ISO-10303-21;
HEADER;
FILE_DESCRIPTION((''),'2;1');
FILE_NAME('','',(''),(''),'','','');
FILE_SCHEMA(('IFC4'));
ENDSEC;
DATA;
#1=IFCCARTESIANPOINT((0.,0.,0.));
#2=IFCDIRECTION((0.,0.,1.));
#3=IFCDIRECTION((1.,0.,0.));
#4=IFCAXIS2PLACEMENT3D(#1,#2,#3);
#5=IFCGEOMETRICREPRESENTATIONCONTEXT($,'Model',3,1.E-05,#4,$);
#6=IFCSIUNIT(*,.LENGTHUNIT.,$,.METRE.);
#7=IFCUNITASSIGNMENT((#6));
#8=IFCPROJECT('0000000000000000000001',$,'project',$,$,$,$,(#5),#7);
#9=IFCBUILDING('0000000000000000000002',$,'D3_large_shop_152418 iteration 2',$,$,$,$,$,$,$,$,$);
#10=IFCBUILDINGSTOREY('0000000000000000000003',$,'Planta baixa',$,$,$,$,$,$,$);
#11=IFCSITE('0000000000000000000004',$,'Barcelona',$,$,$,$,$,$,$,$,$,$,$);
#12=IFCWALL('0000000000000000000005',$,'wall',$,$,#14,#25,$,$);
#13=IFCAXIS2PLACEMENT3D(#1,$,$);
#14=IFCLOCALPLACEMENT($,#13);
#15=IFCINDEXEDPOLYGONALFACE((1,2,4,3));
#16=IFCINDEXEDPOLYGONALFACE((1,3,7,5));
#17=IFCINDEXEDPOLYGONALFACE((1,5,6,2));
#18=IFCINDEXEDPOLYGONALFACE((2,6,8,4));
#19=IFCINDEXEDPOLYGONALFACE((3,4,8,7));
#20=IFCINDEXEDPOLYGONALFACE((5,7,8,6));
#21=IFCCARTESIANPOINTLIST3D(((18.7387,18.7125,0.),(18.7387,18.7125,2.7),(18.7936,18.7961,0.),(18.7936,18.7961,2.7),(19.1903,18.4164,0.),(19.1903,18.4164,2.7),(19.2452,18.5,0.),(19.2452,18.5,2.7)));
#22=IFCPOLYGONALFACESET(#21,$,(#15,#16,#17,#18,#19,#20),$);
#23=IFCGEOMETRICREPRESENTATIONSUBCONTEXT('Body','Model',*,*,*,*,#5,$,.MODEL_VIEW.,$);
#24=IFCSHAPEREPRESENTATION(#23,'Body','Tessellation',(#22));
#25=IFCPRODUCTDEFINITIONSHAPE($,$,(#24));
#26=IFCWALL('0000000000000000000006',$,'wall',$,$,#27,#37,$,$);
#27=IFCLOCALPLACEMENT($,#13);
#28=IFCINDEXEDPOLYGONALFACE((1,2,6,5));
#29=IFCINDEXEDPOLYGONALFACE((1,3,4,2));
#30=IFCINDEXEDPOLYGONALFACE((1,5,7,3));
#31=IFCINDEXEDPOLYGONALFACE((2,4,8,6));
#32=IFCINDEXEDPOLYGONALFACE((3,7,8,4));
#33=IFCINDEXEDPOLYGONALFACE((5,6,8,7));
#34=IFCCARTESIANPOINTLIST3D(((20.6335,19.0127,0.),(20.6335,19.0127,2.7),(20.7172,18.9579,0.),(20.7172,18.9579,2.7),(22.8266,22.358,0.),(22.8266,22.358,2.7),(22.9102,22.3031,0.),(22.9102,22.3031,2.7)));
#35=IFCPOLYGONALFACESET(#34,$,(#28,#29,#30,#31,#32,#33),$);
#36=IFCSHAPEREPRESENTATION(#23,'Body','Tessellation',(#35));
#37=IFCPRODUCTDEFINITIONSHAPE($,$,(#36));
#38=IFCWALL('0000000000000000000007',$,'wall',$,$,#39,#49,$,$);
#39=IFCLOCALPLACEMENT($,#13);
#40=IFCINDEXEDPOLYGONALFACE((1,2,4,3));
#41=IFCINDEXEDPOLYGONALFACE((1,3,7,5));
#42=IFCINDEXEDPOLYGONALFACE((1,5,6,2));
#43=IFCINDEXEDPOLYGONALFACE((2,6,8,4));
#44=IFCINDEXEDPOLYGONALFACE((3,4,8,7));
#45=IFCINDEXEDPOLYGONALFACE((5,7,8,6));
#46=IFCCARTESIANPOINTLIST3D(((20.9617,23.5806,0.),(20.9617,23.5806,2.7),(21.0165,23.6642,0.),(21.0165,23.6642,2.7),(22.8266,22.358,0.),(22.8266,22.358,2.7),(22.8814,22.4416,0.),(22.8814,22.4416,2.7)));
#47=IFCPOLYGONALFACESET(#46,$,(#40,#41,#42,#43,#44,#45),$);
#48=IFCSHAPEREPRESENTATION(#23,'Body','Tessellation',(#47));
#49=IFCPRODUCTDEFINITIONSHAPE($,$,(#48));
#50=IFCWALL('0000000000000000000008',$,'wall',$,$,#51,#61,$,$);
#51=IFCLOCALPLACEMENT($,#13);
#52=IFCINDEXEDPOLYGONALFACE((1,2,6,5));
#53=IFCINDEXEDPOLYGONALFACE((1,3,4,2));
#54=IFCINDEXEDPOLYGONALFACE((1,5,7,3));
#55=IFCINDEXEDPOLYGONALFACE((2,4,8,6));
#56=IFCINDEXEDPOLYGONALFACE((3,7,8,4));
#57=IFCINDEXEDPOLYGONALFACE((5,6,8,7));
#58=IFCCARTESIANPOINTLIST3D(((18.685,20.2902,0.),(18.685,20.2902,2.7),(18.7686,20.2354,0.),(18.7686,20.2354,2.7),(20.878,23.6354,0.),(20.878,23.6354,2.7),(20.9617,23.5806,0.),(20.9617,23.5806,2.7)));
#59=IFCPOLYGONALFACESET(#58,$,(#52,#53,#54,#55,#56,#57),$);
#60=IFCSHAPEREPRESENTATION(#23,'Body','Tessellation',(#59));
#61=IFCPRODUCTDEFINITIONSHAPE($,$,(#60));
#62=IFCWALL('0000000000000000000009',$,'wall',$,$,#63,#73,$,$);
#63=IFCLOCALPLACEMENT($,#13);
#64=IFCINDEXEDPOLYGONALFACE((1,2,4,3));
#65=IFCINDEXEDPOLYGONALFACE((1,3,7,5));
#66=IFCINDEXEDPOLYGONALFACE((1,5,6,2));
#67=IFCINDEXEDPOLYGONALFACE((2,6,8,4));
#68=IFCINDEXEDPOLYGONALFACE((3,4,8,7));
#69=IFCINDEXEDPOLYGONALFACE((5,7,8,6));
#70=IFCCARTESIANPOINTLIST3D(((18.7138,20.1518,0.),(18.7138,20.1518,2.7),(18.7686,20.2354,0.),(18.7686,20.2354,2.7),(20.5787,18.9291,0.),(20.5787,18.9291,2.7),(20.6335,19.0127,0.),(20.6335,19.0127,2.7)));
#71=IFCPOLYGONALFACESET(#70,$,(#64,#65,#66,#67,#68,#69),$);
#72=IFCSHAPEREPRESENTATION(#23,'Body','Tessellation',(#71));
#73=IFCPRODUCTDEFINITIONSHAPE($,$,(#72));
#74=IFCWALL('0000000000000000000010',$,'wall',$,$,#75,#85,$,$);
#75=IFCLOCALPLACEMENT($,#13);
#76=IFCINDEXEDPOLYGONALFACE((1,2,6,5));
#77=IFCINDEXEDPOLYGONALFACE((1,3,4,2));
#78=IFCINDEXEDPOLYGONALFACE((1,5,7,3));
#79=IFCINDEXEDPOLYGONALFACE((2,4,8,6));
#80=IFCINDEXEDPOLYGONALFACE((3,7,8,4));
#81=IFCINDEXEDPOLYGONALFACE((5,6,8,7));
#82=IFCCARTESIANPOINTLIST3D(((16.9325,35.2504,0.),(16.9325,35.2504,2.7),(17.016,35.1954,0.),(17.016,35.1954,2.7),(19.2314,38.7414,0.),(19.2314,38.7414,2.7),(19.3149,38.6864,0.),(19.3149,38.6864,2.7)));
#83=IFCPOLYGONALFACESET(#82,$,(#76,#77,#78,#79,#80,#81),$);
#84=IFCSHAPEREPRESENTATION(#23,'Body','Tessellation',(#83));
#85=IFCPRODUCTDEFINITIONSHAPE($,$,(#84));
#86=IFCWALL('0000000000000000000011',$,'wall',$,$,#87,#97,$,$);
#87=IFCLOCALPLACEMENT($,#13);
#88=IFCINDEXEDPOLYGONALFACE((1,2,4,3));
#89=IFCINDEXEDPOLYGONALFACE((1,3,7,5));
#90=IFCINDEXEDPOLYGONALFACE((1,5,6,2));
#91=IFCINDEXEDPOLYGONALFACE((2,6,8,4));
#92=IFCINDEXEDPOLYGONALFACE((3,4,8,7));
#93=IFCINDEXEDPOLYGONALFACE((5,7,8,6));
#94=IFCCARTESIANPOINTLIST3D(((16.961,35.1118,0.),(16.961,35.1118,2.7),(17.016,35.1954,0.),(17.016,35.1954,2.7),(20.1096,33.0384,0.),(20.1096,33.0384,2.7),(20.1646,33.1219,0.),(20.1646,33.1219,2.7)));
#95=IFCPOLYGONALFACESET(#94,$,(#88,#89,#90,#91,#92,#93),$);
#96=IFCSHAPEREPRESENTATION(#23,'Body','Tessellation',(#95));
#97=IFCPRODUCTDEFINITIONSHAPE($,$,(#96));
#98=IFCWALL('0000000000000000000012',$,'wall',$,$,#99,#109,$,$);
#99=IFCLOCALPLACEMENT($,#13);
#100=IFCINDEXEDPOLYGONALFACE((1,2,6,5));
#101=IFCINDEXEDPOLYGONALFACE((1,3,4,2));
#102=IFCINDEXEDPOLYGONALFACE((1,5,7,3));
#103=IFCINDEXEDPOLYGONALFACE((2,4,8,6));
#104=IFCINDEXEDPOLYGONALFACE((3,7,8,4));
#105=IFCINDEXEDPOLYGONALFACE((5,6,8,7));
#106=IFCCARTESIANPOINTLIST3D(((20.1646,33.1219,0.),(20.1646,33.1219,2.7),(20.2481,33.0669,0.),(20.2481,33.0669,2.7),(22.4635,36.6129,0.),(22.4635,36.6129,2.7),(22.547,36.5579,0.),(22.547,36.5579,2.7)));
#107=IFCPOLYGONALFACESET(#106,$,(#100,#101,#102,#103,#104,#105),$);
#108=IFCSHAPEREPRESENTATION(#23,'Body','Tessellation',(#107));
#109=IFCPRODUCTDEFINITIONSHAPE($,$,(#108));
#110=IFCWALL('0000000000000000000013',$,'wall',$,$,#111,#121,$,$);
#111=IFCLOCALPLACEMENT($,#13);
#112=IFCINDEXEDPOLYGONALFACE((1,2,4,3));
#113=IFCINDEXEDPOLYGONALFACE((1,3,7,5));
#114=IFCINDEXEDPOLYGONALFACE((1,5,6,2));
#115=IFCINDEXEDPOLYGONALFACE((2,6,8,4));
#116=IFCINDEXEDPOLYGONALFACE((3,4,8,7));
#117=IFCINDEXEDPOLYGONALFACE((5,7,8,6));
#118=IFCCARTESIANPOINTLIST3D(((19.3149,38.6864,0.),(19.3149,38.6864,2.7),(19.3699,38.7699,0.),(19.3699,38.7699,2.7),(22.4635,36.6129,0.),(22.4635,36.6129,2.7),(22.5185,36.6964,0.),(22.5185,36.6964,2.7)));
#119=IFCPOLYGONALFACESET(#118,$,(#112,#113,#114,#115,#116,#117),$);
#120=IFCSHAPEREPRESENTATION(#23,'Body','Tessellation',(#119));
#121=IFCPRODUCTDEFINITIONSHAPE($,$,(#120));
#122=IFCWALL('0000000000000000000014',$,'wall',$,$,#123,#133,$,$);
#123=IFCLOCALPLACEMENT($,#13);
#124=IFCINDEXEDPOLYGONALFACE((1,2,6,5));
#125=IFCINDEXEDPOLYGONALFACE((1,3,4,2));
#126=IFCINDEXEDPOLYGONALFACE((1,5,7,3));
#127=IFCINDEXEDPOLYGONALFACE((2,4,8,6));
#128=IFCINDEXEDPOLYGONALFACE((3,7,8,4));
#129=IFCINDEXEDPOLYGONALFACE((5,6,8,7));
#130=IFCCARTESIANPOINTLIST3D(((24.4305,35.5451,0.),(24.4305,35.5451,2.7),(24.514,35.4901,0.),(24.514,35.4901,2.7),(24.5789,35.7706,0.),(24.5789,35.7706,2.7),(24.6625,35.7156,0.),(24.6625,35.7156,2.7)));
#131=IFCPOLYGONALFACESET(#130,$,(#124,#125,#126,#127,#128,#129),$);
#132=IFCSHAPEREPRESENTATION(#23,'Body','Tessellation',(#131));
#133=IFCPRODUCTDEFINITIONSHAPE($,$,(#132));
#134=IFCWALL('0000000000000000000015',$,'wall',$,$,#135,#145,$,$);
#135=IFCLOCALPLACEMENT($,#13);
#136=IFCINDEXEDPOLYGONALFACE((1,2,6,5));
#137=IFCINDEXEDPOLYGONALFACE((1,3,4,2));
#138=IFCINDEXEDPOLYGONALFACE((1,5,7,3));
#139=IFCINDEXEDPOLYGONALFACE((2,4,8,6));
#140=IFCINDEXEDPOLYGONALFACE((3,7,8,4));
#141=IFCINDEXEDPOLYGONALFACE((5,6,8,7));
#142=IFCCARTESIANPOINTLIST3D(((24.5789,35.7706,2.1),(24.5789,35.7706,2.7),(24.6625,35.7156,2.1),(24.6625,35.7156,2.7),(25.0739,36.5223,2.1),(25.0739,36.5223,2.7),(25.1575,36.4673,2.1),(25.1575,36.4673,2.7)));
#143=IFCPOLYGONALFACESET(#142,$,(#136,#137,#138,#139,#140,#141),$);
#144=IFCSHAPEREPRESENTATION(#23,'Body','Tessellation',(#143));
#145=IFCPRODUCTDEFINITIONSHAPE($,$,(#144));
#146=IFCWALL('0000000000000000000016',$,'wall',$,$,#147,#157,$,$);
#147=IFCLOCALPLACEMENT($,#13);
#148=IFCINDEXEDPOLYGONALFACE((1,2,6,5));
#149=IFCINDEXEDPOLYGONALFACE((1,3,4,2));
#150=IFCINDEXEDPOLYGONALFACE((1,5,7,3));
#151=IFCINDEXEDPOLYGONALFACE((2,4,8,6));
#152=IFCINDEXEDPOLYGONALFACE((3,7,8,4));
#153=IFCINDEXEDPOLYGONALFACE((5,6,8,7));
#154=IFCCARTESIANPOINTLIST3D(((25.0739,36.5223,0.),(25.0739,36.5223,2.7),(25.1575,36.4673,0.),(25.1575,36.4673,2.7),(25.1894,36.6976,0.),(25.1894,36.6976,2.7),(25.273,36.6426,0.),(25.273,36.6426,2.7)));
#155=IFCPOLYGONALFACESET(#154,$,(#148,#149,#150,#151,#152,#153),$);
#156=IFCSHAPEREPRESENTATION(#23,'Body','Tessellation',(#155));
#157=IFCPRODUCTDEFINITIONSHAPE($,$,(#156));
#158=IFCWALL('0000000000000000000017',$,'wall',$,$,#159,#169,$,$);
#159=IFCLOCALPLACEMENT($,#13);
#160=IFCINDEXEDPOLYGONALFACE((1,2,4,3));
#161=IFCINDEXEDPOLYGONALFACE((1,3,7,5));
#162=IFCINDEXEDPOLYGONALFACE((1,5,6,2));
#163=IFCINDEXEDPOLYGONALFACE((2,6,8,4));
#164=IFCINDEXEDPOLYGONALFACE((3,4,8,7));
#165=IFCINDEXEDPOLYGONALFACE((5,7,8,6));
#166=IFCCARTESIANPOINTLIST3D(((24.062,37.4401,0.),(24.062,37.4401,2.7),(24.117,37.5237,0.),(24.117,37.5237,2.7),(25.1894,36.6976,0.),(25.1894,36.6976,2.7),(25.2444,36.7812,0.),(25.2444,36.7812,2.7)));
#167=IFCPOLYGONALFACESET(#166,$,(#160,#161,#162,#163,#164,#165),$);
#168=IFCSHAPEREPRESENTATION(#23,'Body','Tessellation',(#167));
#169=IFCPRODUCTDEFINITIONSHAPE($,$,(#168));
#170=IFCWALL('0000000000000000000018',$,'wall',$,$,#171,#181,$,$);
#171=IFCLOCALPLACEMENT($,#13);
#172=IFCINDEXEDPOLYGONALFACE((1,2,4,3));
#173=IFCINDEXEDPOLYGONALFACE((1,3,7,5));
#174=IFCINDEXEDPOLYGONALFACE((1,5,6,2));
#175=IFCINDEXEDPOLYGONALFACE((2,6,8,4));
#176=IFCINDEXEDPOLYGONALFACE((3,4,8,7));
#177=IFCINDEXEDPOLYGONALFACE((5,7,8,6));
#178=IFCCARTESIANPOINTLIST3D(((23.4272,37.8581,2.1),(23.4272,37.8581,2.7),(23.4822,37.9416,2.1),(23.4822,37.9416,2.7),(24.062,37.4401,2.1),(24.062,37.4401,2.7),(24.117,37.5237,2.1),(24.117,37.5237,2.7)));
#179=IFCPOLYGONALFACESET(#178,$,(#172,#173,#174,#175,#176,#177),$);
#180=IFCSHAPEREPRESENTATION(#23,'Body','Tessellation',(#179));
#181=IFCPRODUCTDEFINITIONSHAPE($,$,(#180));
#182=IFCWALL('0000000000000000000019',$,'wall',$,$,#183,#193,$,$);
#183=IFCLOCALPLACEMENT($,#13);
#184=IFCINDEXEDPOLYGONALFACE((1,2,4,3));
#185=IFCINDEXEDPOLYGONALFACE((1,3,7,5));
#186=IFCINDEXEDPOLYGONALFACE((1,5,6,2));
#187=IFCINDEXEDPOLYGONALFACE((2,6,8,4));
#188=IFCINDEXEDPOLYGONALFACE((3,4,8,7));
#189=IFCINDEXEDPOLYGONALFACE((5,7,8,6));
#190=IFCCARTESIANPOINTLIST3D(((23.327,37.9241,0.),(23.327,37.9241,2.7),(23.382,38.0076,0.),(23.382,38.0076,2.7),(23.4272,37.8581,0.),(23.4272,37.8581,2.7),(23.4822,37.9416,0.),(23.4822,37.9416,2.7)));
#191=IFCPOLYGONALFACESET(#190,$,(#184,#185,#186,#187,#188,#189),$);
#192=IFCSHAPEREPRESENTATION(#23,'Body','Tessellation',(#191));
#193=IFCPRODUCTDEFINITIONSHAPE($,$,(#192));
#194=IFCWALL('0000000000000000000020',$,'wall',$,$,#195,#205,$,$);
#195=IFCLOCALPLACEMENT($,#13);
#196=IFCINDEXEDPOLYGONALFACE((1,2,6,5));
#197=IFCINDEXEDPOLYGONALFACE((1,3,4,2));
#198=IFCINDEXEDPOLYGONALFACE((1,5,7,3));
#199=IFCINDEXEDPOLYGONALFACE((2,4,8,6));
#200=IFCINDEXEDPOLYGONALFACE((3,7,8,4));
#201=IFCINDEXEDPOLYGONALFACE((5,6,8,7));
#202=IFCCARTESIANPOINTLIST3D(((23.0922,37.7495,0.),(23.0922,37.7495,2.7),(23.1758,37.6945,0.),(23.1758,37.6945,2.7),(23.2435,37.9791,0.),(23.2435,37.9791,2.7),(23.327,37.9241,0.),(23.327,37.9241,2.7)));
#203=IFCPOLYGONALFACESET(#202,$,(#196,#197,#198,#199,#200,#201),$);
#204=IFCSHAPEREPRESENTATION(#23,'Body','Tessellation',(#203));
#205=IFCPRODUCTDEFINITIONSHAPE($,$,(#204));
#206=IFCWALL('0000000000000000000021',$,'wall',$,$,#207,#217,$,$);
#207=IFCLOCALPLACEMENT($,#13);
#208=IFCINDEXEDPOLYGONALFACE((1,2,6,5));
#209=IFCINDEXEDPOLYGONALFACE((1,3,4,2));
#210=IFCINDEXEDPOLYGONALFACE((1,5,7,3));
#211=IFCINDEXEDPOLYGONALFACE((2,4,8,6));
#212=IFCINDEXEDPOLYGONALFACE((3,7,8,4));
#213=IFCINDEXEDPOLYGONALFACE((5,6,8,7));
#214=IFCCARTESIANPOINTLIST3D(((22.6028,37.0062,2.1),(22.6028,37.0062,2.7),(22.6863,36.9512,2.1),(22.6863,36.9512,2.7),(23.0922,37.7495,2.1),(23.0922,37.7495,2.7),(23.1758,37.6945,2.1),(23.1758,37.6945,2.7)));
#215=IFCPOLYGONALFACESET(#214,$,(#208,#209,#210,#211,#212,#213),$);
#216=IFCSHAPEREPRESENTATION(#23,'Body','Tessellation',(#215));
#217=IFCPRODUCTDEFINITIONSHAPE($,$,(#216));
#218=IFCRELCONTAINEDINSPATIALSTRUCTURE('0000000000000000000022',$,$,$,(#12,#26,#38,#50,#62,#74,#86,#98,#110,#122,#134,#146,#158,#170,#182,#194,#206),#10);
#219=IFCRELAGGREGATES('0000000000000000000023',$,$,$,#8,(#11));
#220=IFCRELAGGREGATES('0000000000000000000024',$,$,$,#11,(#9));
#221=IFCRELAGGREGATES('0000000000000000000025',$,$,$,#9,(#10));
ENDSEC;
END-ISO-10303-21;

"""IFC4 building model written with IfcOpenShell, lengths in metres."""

from ifc_helpers import new_model, si_unit, frame, origin, origin_with_axes, place, context, subcontext, project, spatial, polyline, outline, extrude, element, save


model = new_model("IFC4")

# Units and contexts
model_context = context("Model", 3, precision=1e-05, world=origin_with_axes())
body_context = subcontext(model_context, "Body", "Model", "MODEL_VIEW")
ifc_project = project(units=[si_unit("LENGTHUNIT", "METRE")], contexts=[model_context])

# Site, building, storey
site = spatial("IfcSite", under=ifc_project, Name="Barcelona")
building = spatial("IfcBuilding", under=site, Name="D3_large_shop_152418 iteration 2")
storey = spatial("IfcBuildingStorey", under=building, Name="Planta baixa")

# Walls
wall_1_placement = place(None, origin_with_axes())
element("IfcWall", 1, at=wall_1_placement, inside=storey, Name="wall", context=body_context, shape_type="SweptSolid", body=[
    extrude(outline(polyline([(19.1903, 18.4164), (18.7387, 18.7125), (18.7936, 18.7961), (19.2452, 18.5), (19.1903, 18.4164)])), origin(), (0.0, 0.0, 1.0), 2.7),
])
wall_2_placement = place(None, origin_with_axes())
element("IfcWall", 2, at=wall_2_placement, inside=storey, Name="wall", context=body_context, shape_type="SweptSolid", body=[
    extrude(outline(polyline([(20.6335, 19.0127), (22.8266, 22.358), (22.9102, 22.3031), (20.7172, 18.9579), (20.6335, 19.0127)])), origin(), (0.0, 0.0, 1.0), 2.7),
])
wall_3_placement = place(None, origin_with_axes())
element("IfcWall", 3, at=wall_3_placement, inside=storey, Name="wall", context=body_context, shape_type="SweptSolid", body=[
    extrude(outline(polyline([(22.8266, 22.358), (20.9617, 23.5806), (21.0165, 23.6642), (22.8814, 22.4416), (22.8266, 22.358)])), origin(), (0.0, 0.0, 1.0), 2.7),
])
wall_4_placement = place(None, origin_with_axes())
element("IfcWall", 4, at=wall_4_placement, inside=storey, Name="wall", context=body_context, shape_type="SweptSolid", body=[
    extrude(outline(polyline([(20.9617, 23.5806), (18.7686, 20.2354), (18.685, 20.2902), (20.878, 23.6354), (20.9617, 23.5806)])), origin(), (0.0, 0.0, 1.0), 2.7),
])
wall_5_placement = place(None, origin_with_axes())
element("IfcWall", 5, at=wall_5_placement, inside=storey, Name="wall", context=body_context, shape_type="SweptSolid", body=[
    extrude(outline(polyline([(18.7686, 20.2354), (20.6335, 19.0127), (20.5787, 18.9291), (18.7138, 20.1518), (18.7686, 20.2354)])), origin(), (0.0, 0.0, 1.0), 2.7),
])
wall_6_placement = place(None, origin_with_axes())
element("IfcWall", 6, at=wall_6_placement, inside=storey, Name="wall", context=body_context, shape_type="SweptSolid", body=[
    extrude(outline(polyline([(19.3149, 38.6864), (17.016, 35.1954), (16.9325, 35.2504), (19.2314, 38.7414), (19.3149, 38.6864)])), origin(), (0.0, 0.0, 1.0), 2.7),
])
wall_7_placement = place(None, origin_with_axes())
element("IfcWall", 7, at=wall_7_placement, inside=storey, Name="wall", context=body_context, shape_type="SweptSolid", body=[
    extrude(outline(polyline([(17.016, 35.1954), (20.1646, 33.1219), (20.1096, 33.0384), (16.961, 35.1118), (17.016, 35.1954)])), origin(), (0.0, 0.0, 1.0), 2.7),
])
wall_8_placement = place(None, origin_with_axes())
element("IfcWall", 8, at=wall_8_placement, inside=storey, Name="wall", context=body_context, shape_type="SweptSolid", body=[
    extrude(outline(polyline([(20.1646, 33.1219), (22.4635, 36.6129), (22.547, 36.5579), (20.2481, 33.0669), (20.1646, 33.1219)])), origin(), (0.0, 0.0, 1.0), 2.7),
])
wall_9_placement = place(None, origin_with_axes())
element("IfcWall", 9, at=wall_9_placement, inside=storey, Name="wall", context=body_context, shape_type="SweptSolid", body=[
    extrude(outline(polyline([(22.4635, 36.6129), (19.3149, 38.6864), (19.3699, 38.7699), (22.5185, 36.6964), (22.4635, 36.6129)])), origin(), (0.0, 0.0, 1.0), 2.7),
])
wall_10_placement = place(None, origin_with_axes())
element("IfcWall", 10, at=wall_10_placement, inside=storey, Name="wall", context=body_context, shape_type="SweptSolid", body=[
    extrude(outline(polyline([(24.4305, 35.5451), (24.5789, 35.7706), (24.6625, 35.7156), (24.514, 35.4901), (24.4305, 35.5451)])), origin(), (0.0, 0.0, 1.0), 2.7),
])
wall_11_placement = place(None, origin_with_axes())
element("IfcWall", 11, at=wall_11_placement, inside=storey, Name="wall", context=body_context, shape_type="SweptSolid", body=[
    extrude(outline(polyline([(24.5789, 35.7706), (25.0739, 36.5223), (25.1575, 36.4673), (24.6625, 35.7156), (24.5789, 35.7706)])), frame((0.0, 0.0, 2.1)), (0.0, 0.0, 1.0), 0.6),
])
wall_12_placement = place(None, origin_with_axes())
element("IfcWall", 12, at=wall_12_placement, inside=storey, Name="wall", context=body_context, shape_type="SweptSolid", body=[
    extrude(outline(polyline([(25.0739, 36.5223), (25.1894, 36.6976), (25.273, 36.6426), (25.1575, 36.4673), (25.0739, 36.5223)])), origin(), (0.0, 0.0, 1.0), 2.7),
])
wall_13_placement = place(None, origin_with_axes())
element("IfcWall", 13, at=wall_13_placement, inside=storey, Name="wall", context=body_context, shape_type="SweptSolid", body=[
    extrude(outline(polyline([(25.1894, 36.6976), (24.062, 37.4401), (24.117, 37.5237), (25.2444, 36.7812), (25.1894, 36.6976)])), origin(), (0.0, 0.0, 1.0), 2.7),
])
wall_14_placement = place(None, origin_with_axes())
element("IfcWall", 14, at=wall_14_placement, inside=storey, Name="wall", context=body_context, shape_type="SweptSolid", body=[
    extrude(outline(polyline([(24.062, 37.4401), (23.4272, 37.8581), (23.4822, 37.9416), (24.117, 37.5237), (24.062, 37.4401)])), frame((0.0, 0.0, 2.1)), (0.0, 0.0, 1.0), 0.6),
])
wall_15_placement = place(None, origin_with_axes())
element("IfcWall", 15, at=wall_15_placement, inside=storey, Name="wall", context=body_context, shape_type="SweptSolid", body=[
    extrude(outline(polyline([(23.4272, 37.8581), (23.327, 37.9241), (23.382, 38.0076), (23.4822, 37.9416), (23.4272, 37.8581)])), origin(), (0.0, 0.0, 1.0), 2.7),
])
wall_16_placement = place(None, origin_with_axes())
element("IfcWall", 16, at=wall_16_placement, inside=storey, Name="wall", context=body_context, shape_type="SweptSolid", body=[
    extrude(outline(polyline([(23.327, 37.9241), (23.1758, 37.6945), (23.0922, 37.7495), (23.2435, 37.9791), (23.327, 37.9241)])), origin(), (0.0, 0.0, 1.0), 2.7),
])
wall_17_placement = place(None, origin_with_axes())
element("IfcWall", 17, at=wall_17_placement, inside=storey, Name="wall", context=body_context, shape_type="SweptSolid", body=[
    extrude(outline(polyline([(23.1758, 37.6945), (22.6863, 36.9512), (22.6028, 37.0062), (23.0922, 37.7495), (23.1758, 37.6945)])), frame((0.0, 0.0, 2.1)), (0.0, 0.0, 1.0), 0.6),
])

save(model, "model.ifc")
